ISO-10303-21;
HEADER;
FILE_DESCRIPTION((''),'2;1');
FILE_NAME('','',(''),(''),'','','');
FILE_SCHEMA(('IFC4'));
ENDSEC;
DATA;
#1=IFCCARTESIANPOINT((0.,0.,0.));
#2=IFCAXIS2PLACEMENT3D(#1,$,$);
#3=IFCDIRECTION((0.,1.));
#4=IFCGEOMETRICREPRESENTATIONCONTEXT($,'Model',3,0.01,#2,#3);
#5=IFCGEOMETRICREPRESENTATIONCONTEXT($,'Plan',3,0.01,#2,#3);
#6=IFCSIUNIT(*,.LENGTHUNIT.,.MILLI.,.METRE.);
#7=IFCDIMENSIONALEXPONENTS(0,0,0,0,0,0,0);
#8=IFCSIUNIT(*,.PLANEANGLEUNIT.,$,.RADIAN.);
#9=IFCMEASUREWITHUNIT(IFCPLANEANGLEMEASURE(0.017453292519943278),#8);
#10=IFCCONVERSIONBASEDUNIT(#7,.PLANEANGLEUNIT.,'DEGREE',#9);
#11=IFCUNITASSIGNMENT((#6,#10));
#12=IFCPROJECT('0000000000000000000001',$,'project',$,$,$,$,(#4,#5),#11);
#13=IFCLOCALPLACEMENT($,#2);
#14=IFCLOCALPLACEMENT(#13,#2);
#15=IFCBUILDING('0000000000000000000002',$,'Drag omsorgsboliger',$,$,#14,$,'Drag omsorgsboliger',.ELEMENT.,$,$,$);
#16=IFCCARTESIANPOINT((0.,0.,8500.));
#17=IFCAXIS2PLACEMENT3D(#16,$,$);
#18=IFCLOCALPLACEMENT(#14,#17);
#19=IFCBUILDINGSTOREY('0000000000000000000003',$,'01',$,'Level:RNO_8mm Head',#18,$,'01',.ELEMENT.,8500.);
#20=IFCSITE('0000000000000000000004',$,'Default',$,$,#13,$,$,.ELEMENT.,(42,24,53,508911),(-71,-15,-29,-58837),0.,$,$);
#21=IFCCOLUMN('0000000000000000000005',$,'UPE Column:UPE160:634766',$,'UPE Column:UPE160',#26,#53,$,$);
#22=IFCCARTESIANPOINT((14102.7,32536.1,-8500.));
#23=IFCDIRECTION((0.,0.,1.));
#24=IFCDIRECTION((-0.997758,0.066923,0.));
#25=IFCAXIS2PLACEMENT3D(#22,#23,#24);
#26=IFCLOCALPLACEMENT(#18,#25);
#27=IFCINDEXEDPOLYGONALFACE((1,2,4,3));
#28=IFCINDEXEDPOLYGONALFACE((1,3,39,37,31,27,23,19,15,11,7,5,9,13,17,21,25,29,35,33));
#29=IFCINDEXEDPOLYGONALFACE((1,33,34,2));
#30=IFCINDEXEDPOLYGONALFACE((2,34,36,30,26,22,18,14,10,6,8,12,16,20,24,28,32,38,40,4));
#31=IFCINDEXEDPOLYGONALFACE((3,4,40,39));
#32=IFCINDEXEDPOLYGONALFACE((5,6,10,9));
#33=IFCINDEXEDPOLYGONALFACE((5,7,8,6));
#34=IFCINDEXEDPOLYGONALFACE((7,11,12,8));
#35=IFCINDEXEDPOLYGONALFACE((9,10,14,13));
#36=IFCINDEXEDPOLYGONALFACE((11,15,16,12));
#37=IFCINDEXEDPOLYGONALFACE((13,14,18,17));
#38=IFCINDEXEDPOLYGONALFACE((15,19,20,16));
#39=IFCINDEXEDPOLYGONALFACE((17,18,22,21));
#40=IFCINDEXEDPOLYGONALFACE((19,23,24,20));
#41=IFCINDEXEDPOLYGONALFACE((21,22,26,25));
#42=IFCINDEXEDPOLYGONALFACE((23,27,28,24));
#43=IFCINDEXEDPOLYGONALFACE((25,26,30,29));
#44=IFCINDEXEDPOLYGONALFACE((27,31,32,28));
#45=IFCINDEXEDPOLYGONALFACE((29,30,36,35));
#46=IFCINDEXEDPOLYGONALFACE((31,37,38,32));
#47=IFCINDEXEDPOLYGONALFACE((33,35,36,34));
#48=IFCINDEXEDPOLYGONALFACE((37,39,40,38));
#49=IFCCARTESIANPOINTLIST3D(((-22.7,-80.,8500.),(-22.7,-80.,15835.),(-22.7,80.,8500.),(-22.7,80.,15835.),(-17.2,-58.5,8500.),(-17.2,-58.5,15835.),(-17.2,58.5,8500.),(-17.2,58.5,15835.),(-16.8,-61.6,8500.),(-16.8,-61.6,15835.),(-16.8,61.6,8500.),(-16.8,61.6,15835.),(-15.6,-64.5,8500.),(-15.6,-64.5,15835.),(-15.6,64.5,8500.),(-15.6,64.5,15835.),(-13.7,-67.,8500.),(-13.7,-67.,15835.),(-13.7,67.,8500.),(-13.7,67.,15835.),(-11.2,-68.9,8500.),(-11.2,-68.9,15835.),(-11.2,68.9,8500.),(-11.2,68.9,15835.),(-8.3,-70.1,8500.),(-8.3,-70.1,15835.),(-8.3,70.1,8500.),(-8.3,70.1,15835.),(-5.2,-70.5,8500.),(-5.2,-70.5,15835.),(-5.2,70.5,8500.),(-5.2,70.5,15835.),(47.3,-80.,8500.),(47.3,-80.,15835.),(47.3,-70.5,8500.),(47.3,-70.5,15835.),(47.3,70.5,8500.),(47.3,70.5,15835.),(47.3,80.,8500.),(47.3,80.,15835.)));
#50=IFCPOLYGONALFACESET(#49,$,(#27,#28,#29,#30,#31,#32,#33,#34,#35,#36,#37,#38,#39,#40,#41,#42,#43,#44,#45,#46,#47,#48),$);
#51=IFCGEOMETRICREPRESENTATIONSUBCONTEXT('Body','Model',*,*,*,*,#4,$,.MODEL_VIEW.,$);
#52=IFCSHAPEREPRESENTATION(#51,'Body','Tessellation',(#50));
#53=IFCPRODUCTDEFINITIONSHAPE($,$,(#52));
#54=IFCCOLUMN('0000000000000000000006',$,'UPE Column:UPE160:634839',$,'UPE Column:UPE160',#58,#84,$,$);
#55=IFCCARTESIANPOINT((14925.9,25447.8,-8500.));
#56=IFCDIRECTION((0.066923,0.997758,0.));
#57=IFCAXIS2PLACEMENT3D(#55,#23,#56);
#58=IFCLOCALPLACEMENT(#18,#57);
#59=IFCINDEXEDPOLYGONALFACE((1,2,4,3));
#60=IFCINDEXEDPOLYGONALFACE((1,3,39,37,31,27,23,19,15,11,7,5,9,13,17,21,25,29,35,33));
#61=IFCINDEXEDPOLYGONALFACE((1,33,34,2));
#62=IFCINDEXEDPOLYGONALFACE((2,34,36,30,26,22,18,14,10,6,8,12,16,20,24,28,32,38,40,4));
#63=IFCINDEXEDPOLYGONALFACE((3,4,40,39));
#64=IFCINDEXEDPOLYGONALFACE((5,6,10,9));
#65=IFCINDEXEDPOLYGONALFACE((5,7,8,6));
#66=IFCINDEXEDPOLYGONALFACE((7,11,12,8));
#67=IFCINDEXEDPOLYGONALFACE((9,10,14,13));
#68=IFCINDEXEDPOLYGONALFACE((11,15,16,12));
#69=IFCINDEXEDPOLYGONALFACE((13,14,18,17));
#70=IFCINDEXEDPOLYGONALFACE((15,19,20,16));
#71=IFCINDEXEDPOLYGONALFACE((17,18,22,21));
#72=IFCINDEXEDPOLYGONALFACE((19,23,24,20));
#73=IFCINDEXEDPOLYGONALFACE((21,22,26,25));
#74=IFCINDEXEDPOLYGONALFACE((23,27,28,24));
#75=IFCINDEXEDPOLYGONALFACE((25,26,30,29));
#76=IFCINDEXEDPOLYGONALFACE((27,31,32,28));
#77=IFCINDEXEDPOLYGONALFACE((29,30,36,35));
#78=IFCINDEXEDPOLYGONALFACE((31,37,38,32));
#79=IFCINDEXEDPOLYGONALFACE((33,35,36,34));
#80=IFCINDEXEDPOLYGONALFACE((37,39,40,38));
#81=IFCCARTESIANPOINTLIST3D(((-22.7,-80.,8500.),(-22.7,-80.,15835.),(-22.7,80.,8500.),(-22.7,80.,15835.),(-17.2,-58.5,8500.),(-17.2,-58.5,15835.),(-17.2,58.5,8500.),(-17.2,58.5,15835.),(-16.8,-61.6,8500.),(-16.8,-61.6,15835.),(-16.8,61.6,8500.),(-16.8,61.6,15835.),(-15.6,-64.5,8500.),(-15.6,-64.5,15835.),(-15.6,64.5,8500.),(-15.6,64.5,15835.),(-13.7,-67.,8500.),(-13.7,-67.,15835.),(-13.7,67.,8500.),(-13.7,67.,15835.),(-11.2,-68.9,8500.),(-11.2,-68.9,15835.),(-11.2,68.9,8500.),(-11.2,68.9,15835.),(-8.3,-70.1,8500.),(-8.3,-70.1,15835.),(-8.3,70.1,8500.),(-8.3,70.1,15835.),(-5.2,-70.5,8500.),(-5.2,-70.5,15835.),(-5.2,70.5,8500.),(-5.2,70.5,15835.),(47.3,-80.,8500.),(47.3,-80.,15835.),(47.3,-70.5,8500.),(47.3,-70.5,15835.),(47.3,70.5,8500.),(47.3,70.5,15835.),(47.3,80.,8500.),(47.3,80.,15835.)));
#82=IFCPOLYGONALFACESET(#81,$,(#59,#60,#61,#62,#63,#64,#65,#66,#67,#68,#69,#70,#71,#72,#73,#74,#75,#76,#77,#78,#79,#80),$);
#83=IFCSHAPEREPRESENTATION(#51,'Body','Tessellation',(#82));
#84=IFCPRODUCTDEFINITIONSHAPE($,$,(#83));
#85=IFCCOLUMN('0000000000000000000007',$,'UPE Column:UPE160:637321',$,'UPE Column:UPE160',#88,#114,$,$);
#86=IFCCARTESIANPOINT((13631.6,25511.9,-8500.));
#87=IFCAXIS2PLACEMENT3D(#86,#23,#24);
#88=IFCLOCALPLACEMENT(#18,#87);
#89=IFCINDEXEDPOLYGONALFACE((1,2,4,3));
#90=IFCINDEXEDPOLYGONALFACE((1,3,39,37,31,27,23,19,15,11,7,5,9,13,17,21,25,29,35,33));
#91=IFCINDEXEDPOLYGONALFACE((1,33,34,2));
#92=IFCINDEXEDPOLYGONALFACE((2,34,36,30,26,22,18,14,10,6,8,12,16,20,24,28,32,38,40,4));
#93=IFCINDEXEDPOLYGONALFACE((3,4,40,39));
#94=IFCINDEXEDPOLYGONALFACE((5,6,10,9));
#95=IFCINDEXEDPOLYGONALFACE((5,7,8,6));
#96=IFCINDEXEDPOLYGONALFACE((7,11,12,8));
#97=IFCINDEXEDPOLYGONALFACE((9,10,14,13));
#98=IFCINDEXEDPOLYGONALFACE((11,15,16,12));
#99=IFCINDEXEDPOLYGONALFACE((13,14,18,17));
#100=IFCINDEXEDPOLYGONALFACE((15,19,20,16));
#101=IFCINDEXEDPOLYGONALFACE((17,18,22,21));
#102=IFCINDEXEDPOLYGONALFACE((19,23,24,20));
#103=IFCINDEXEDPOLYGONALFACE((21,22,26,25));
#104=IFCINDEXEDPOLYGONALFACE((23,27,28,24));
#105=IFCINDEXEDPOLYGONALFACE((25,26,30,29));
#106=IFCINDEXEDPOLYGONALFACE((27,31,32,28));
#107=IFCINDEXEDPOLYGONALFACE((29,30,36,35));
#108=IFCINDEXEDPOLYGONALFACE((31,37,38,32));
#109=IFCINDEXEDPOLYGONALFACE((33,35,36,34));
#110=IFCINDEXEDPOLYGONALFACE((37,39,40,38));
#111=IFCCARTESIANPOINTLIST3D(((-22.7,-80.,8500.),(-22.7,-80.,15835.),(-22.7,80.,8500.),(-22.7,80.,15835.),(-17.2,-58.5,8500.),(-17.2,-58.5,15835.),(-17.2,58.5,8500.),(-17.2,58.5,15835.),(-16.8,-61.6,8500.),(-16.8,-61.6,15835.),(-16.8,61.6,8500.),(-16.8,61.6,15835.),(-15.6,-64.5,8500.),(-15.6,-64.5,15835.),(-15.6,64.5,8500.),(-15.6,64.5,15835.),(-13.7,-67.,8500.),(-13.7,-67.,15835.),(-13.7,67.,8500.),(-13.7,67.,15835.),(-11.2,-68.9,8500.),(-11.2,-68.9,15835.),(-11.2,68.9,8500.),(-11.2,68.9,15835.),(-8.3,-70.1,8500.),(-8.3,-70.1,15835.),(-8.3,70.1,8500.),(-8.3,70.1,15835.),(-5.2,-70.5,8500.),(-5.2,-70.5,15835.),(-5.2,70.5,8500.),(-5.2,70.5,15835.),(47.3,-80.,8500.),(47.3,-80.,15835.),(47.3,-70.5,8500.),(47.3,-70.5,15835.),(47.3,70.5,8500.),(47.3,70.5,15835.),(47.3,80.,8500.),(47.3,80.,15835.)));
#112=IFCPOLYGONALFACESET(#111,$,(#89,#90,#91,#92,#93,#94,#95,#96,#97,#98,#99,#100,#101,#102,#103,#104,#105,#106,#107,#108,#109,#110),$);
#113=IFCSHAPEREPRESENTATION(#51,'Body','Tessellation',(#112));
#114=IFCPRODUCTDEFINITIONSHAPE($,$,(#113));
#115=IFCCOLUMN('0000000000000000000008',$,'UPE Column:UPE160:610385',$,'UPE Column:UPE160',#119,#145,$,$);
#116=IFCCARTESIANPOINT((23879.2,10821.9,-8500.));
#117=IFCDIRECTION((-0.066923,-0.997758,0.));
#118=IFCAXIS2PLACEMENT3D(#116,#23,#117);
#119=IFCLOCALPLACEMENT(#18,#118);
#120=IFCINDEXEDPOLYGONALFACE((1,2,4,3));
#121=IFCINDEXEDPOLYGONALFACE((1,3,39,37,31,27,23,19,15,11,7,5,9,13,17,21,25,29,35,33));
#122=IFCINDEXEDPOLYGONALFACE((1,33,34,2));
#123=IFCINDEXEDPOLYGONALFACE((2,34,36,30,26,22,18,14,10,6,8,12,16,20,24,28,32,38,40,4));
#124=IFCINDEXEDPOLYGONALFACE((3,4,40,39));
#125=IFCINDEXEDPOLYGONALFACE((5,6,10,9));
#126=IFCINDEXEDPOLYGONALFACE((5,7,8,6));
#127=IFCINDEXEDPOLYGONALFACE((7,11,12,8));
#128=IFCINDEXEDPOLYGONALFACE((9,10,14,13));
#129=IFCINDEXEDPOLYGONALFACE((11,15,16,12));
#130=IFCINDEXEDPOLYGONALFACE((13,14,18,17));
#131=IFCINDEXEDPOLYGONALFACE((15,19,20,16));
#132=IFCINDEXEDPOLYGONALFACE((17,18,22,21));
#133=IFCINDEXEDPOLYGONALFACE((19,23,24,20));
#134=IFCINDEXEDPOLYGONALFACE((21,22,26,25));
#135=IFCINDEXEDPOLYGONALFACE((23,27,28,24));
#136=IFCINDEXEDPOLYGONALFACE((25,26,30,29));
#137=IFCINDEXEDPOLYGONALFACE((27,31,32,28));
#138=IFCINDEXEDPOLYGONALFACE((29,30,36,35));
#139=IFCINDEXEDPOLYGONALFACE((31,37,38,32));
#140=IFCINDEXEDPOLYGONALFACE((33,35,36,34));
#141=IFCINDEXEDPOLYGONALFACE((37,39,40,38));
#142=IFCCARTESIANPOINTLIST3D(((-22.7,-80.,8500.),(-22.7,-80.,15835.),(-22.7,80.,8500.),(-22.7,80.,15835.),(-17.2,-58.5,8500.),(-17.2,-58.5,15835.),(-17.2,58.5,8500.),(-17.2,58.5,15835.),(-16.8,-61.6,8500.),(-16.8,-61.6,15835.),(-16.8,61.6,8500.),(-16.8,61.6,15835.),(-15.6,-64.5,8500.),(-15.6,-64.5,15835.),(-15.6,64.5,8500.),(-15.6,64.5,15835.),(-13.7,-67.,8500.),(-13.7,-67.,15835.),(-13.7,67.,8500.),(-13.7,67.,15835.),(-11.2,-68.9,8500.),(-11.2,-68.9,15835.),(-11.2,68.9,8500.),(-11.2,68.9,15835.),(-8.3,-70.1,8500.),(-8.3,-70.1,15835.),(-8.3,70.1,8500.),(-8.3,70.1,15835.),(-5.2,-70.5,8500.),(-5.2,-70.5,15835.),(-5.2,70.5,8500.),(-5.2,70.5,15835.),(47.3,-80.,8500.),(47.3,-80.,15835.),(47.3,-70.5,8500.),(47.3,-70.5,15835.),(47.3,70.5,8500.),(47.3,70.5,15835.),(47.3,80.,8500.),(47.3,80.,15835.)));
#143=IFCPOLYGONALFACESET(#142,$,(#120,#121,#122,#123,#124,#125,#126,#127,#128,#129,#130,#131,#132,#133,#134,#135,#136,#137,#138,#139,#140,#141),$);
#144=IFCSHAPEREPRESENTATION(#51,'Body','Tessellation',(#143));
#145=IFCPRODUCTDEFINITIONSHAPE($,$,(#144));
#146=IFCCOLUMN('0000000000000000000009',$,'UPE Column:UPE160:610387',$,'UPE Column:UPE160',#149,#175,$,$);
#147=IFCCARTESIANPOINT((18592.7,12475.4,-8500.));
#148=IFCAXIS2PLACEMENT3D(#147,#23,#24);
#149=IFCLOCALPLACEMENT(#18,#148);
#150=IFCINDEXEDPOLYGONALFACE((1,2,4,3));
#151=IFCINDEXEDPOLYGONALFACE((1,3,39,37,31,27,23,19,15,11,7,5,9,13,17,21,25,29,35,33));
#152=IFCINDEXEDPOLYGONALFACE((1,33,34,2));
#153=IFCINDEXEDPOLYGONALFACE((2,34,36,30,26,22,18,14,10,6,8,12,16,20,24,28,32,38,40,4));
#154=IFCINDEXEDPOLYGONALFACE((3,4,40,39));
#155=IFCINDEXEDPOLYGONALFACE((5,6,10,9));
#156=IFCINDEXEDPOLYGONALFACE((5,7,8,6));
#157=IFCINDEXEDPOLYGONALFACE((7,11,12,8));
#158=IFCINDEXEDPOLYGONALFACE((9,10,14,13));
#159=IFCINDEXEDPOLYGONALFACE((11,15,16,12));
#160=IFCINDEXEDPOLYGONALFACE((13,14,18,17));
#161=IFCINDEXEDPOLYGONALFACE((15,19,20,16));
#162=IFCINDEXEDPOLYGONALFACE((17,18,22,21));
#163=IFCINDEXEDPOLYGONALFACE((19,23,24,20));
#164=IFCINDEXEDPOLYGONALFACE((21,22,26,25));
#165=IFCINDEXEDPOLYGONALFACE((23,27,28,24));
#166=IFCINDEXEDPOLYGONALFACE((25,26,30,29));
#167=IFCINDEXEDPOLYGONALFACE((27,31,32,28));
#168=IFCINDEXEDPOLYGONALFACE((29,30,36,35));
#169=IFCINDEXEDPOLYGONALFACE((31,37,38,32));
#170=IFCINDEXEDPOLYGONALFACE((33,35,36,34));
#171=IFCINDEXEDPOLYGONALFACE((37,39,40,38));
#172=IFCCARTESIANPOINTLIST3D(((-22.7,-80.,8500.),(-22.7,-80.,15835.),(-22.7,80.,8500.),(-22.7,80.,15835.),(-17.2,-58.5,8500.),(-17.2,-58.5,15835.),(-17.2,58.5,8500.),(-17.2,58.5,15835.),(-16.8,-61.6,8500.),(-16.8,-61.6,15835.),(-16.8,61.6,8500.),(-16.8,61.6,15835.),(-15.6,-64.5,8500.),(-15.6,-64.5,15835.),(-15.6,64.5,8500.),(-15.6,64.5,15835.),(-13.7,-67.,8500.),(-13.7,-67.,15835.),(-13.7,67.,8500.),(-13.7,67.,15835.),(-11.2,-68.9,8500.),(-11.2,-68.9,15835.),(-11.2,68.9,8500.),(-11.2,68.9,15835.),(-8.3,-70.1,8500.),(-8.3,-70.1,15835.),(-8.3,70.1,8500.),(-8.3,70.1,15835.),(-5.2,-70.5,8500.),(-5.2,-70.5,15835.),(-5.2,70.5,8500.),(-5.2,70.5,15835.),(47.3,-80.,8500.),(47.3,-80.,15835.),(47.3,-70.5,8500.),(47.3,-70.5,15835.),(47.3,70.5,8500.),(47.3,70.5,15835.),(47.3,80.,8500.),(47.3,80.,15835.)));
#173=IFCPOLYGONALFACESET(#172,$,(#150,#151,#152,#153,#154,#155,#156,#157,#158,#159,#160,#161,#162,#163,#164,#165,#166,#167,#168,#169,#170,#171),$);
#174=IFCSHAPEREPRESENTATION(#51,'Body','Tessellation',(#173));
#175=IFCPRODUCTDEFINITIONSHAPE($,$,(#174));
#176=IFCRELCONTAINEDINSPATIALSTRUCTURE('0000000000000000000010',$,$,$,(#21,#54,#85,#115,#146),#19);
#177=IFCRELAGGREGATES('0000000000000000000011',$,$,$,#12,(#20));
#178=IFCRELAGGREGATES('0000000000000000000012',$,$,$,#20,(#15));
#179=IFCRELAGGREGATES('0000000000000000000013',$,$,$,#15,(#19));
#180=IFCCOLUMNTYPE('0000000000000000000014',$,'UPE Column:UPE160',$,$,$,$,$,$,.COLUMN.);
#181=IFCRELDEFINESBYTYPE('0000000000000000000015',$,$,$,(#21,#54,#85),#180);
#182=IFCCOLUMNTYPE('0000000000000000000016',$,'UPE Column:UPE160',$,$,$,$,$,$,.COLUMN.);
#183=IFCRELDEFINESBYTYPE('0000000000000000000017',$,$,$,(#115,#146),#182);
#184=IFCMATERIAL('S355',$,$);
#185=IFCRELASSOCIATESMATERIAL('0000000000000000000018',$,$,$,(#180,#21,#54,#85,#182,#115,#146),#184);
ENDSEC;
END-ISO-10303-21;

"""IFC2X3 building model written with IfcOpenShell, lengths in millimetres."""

from ifc_helpers import new_model, entity, si_unit, converted_unit, direction, frame, frame_2d, origin, place, context, subcontext, project, spatial, polyline, circle_curve, parameter, trimmed, segment, composite_curve, outline, extrude, source, transform, mapped, material, type_object, type_shapes, element, save


model = new_model("IFC2X3")

# Units and contexts
model_context = context("Model", 3, precision=0.01, world=origin(), true_north=direction((0.0, 1.0)))
plan_context = context("Plan", 3, precision=0.01, world=origin(), true_north=direction((0.0, 1.0)))
body_context = subcontext(model_context, "Body", "Model", "MODEL_VIEW")
ifc_project = project(units=[si_unit("LENGTHUNIT", "METRE", prefix="MILLI"), converted_unit("PLANEANGLEUNIT", "DEGREE", entity("IfcPlaneAngleMeasure", 0.017453292519943278), si_unit("PLANEANGLEUNIT", "RADIAN"), dimensions=[0, 0, 0, 0, 0, 0, 0])], contexts=[model_context, plan_context])

# Site, building, storey
site_placement = place(None, origin())
site = spatial("IfcSite", under=ifc_project, at=site_placement, Name="Default", CompositionType="ELEMENT", RefLatitude=(42, 24, 53, 508911), RefLongitude=(-71, -15, -29, -58837), RefElevation=0.0)
building_placement = place(site_placement, origin())
building = spatial("IfcBuilding", under=site, at=building_placement, Name="Drag omsorgsboliger", LongName="Drag omsorgsboliger", CompositionType="ELEMENT")
storey_placement = place(building_placement, frame((0.0, 0.0, 8500.0)))
storey = spatial("IfcBuildingStorey", under=building, at=storey_placement, Name="01", ObjectType="Level:RNO_8mm Head", LongName="01", CompositionType="ELEMENT", Elevation=8500.0)

# Columns
ifc_material_1 = material(Name="S355")
column_type_1 = type_object("IfcColumnType", Name="UPE Column:UPE160", PredefinedType="COLUMN", material=ifc_material_1)
shared_shape_1 = source(origin(), body_context, "Body", "SweptSolid", [
    extrude(outline(composite_curve([segment(polyline([(-37.4, -80.0), (32.6, -80.0)]), True, "CONTINUOUS"), segment(polyline([(32.6, -80.0), (32.6, 80.0)]), True, "CONTINUOUS"), segment(polyline([(32.6, 80.0), (-37.4, 80.0)]), True, "CONTINUOUS"), segment(polyline([(-37.4, 80.0), (-37.4, 70.5)]), True, "CONTINUOUS"), segment(polyline([(-37.4, 70.5), (15.1, 70.5)]), True, "CONTINUOUS"), segment(trimmed(circle_curve(frame_2d((15.1, 58.5), x_axis=(-1.0, 0.0)), 12.0), [parameter(180.0)], [parameter(270.0)], True, "PARAMETER"), False, "CONTINUOUS"), segment(polyline([(27.1, 58.5), (27.1, -58.5)]), True, "CONTINUOUS"), segment(trimmed(circle_curve(frame_2d((15.1, -58.5), x_axis=(-1.0, 0.0)), 12.0), [parameter(90.0)], [parameter(180.0)], True, "PARAMETER"), False, "CONTINUOUS"), segment(polyline([(15.1, -70.5), (-37.4, -70.5)]), True, "CONTINUOUS"), segment(polyline([(-37.4, -70.5), (-37.4, -80.0)]), True, "CONTINUOUS")], self_intersect=False)), frame((9.9, 0.0, 8500.0), z_axis=(0.0, 0.0, 1.0), x_axis=(-1.0, 0.0, 0.0)), (0.0, 0.0, 1.0), 7335.0),
])
type_shapes(column_type_1, [shared_shape_1])
for number, where, z_axis, x_axis, name in (
    (1, (14102.7, 32536.1, -8500.0), (0.0, 0.0, 1.0), (-0.997758, 0.066923, 0.0), "UPE Column:UPE160:634766"),
    (2, (14925.9, 25447.8, -8500.0), (0.0, 0.0, 1.0), (0.066923, 0.997758, 0.0), "UPE Column:UPE160:634839"),
    (3, (13631.6, 25511.9, -8500.0), (0.0, 0.0, 1.0), (-0.997758, 0.066923, 0.0), "UPE Column:UPE160:637321"),
):
    element("IfcColumn", number, at=place(storey_placement, frame(where, z_axis=z_axis, x_axis=x_axis)), inside=storey, type_object=column_type_1, material=ifc_material_1, Name=name, ObjectType="UPE Column:UPE160", context=body_context, shape_type="MappedRepresentation", body=[
        mapped(shared_shape_1, transform((0.0, 0.0, 0.0), scale=1.0)),
    ])
column_type_2 = type_object("IfcColumnType", Name="UPE Column:UPE160", PredefinedType="COLUMN", material=ifc_material_1)
shared_shape_2 = source(origin(), body_context, "Body", "SweptSolid", [
    extrude(outline(composite_curve([segment(polyline([(-80.0, -37.4), (-70.5, -37.4)]), True, "CONTINUOUS"), segment(polyline([(-70.5, -37.4), (-70.5, 15.1)]), True, "CONTINUOUS"), segment(trimmed(circle_curve(frame_2d((-58.5, 15.1), x_axis=(0.0, -1.0)), 12.0), [parameter(180.0)], [parameter(270.0)], True, "PARAMETER"), False, "CONTINUOUS"), segment(polyline([(-58.5, 27.1), (58.5, 27.1)]), True, "CONTINUOUS"), segment(trimmed(circle_curve(frame_2d((58.5, 15.1), x_axis=(0.0, -1.0)), 12.0), [parameter(90.0)], [parameter(180.0)], True, "PARAMETER"), False, "CONTINUOUS"), segment(polyline([(70.5, 15.1), (70.5, -37.4)]), True, "CONTINUOUS"), segment(polyline([(70.5, -37.4), (80.0, -37.4)]), True, "CONTINUOUS"), segment(polyline([(80.0, -37.4), (80.0, 32.6)]), True, "CONTINUOUS"), segment(polyline([(80.0, 32.6), (-80.0, 32.6)]), True, "CONTINUOUS"), segment(polyline([(-80.0, 32.6), (-80.0, -37.4)]), True, "CONTINUOUS")], self_intersect=False)), frame((9.9, 0.0, 8500.0), z_axis=(0.0, 0.0, 1.0), x_axis=(0.0, 1.0, 0.0)), (0.0, 0.0, 1.0), 7335.0),
])
type_shapes(column_type_2, [shared_shape_2])
for number, where, z_axis, x_axis, name in (
    (4, (23879.2, 10821.9, -8500.0), (0.0, 0.0, 1.0), (-0.066923, -0.997758, 0.0), "UPE Column:UPE160:610385"),
    (5, (18592.7, 12475.4, -8500.0), (0.0, 0.0, 1.0), (-0.997758, 0.066923, 0.0), "UPE Column:UPE160:610387"),
):
    element("IfcColumn", number, at=place(storey_placement, frame(where, z_axis=z_axis, x_axis=x_axis)), inside=storey, type_object=column_type_2, material=ifc_material_1, Name=name, ObjectType="UPE Column:UPE160", context=body_context, shape_type="MappedRepresentation", body=[
        mapped(shared_shape_2, transform((0.0, 0.0, 0.0), scale=1.0)),
    ])

save(model, "model.ifc")
